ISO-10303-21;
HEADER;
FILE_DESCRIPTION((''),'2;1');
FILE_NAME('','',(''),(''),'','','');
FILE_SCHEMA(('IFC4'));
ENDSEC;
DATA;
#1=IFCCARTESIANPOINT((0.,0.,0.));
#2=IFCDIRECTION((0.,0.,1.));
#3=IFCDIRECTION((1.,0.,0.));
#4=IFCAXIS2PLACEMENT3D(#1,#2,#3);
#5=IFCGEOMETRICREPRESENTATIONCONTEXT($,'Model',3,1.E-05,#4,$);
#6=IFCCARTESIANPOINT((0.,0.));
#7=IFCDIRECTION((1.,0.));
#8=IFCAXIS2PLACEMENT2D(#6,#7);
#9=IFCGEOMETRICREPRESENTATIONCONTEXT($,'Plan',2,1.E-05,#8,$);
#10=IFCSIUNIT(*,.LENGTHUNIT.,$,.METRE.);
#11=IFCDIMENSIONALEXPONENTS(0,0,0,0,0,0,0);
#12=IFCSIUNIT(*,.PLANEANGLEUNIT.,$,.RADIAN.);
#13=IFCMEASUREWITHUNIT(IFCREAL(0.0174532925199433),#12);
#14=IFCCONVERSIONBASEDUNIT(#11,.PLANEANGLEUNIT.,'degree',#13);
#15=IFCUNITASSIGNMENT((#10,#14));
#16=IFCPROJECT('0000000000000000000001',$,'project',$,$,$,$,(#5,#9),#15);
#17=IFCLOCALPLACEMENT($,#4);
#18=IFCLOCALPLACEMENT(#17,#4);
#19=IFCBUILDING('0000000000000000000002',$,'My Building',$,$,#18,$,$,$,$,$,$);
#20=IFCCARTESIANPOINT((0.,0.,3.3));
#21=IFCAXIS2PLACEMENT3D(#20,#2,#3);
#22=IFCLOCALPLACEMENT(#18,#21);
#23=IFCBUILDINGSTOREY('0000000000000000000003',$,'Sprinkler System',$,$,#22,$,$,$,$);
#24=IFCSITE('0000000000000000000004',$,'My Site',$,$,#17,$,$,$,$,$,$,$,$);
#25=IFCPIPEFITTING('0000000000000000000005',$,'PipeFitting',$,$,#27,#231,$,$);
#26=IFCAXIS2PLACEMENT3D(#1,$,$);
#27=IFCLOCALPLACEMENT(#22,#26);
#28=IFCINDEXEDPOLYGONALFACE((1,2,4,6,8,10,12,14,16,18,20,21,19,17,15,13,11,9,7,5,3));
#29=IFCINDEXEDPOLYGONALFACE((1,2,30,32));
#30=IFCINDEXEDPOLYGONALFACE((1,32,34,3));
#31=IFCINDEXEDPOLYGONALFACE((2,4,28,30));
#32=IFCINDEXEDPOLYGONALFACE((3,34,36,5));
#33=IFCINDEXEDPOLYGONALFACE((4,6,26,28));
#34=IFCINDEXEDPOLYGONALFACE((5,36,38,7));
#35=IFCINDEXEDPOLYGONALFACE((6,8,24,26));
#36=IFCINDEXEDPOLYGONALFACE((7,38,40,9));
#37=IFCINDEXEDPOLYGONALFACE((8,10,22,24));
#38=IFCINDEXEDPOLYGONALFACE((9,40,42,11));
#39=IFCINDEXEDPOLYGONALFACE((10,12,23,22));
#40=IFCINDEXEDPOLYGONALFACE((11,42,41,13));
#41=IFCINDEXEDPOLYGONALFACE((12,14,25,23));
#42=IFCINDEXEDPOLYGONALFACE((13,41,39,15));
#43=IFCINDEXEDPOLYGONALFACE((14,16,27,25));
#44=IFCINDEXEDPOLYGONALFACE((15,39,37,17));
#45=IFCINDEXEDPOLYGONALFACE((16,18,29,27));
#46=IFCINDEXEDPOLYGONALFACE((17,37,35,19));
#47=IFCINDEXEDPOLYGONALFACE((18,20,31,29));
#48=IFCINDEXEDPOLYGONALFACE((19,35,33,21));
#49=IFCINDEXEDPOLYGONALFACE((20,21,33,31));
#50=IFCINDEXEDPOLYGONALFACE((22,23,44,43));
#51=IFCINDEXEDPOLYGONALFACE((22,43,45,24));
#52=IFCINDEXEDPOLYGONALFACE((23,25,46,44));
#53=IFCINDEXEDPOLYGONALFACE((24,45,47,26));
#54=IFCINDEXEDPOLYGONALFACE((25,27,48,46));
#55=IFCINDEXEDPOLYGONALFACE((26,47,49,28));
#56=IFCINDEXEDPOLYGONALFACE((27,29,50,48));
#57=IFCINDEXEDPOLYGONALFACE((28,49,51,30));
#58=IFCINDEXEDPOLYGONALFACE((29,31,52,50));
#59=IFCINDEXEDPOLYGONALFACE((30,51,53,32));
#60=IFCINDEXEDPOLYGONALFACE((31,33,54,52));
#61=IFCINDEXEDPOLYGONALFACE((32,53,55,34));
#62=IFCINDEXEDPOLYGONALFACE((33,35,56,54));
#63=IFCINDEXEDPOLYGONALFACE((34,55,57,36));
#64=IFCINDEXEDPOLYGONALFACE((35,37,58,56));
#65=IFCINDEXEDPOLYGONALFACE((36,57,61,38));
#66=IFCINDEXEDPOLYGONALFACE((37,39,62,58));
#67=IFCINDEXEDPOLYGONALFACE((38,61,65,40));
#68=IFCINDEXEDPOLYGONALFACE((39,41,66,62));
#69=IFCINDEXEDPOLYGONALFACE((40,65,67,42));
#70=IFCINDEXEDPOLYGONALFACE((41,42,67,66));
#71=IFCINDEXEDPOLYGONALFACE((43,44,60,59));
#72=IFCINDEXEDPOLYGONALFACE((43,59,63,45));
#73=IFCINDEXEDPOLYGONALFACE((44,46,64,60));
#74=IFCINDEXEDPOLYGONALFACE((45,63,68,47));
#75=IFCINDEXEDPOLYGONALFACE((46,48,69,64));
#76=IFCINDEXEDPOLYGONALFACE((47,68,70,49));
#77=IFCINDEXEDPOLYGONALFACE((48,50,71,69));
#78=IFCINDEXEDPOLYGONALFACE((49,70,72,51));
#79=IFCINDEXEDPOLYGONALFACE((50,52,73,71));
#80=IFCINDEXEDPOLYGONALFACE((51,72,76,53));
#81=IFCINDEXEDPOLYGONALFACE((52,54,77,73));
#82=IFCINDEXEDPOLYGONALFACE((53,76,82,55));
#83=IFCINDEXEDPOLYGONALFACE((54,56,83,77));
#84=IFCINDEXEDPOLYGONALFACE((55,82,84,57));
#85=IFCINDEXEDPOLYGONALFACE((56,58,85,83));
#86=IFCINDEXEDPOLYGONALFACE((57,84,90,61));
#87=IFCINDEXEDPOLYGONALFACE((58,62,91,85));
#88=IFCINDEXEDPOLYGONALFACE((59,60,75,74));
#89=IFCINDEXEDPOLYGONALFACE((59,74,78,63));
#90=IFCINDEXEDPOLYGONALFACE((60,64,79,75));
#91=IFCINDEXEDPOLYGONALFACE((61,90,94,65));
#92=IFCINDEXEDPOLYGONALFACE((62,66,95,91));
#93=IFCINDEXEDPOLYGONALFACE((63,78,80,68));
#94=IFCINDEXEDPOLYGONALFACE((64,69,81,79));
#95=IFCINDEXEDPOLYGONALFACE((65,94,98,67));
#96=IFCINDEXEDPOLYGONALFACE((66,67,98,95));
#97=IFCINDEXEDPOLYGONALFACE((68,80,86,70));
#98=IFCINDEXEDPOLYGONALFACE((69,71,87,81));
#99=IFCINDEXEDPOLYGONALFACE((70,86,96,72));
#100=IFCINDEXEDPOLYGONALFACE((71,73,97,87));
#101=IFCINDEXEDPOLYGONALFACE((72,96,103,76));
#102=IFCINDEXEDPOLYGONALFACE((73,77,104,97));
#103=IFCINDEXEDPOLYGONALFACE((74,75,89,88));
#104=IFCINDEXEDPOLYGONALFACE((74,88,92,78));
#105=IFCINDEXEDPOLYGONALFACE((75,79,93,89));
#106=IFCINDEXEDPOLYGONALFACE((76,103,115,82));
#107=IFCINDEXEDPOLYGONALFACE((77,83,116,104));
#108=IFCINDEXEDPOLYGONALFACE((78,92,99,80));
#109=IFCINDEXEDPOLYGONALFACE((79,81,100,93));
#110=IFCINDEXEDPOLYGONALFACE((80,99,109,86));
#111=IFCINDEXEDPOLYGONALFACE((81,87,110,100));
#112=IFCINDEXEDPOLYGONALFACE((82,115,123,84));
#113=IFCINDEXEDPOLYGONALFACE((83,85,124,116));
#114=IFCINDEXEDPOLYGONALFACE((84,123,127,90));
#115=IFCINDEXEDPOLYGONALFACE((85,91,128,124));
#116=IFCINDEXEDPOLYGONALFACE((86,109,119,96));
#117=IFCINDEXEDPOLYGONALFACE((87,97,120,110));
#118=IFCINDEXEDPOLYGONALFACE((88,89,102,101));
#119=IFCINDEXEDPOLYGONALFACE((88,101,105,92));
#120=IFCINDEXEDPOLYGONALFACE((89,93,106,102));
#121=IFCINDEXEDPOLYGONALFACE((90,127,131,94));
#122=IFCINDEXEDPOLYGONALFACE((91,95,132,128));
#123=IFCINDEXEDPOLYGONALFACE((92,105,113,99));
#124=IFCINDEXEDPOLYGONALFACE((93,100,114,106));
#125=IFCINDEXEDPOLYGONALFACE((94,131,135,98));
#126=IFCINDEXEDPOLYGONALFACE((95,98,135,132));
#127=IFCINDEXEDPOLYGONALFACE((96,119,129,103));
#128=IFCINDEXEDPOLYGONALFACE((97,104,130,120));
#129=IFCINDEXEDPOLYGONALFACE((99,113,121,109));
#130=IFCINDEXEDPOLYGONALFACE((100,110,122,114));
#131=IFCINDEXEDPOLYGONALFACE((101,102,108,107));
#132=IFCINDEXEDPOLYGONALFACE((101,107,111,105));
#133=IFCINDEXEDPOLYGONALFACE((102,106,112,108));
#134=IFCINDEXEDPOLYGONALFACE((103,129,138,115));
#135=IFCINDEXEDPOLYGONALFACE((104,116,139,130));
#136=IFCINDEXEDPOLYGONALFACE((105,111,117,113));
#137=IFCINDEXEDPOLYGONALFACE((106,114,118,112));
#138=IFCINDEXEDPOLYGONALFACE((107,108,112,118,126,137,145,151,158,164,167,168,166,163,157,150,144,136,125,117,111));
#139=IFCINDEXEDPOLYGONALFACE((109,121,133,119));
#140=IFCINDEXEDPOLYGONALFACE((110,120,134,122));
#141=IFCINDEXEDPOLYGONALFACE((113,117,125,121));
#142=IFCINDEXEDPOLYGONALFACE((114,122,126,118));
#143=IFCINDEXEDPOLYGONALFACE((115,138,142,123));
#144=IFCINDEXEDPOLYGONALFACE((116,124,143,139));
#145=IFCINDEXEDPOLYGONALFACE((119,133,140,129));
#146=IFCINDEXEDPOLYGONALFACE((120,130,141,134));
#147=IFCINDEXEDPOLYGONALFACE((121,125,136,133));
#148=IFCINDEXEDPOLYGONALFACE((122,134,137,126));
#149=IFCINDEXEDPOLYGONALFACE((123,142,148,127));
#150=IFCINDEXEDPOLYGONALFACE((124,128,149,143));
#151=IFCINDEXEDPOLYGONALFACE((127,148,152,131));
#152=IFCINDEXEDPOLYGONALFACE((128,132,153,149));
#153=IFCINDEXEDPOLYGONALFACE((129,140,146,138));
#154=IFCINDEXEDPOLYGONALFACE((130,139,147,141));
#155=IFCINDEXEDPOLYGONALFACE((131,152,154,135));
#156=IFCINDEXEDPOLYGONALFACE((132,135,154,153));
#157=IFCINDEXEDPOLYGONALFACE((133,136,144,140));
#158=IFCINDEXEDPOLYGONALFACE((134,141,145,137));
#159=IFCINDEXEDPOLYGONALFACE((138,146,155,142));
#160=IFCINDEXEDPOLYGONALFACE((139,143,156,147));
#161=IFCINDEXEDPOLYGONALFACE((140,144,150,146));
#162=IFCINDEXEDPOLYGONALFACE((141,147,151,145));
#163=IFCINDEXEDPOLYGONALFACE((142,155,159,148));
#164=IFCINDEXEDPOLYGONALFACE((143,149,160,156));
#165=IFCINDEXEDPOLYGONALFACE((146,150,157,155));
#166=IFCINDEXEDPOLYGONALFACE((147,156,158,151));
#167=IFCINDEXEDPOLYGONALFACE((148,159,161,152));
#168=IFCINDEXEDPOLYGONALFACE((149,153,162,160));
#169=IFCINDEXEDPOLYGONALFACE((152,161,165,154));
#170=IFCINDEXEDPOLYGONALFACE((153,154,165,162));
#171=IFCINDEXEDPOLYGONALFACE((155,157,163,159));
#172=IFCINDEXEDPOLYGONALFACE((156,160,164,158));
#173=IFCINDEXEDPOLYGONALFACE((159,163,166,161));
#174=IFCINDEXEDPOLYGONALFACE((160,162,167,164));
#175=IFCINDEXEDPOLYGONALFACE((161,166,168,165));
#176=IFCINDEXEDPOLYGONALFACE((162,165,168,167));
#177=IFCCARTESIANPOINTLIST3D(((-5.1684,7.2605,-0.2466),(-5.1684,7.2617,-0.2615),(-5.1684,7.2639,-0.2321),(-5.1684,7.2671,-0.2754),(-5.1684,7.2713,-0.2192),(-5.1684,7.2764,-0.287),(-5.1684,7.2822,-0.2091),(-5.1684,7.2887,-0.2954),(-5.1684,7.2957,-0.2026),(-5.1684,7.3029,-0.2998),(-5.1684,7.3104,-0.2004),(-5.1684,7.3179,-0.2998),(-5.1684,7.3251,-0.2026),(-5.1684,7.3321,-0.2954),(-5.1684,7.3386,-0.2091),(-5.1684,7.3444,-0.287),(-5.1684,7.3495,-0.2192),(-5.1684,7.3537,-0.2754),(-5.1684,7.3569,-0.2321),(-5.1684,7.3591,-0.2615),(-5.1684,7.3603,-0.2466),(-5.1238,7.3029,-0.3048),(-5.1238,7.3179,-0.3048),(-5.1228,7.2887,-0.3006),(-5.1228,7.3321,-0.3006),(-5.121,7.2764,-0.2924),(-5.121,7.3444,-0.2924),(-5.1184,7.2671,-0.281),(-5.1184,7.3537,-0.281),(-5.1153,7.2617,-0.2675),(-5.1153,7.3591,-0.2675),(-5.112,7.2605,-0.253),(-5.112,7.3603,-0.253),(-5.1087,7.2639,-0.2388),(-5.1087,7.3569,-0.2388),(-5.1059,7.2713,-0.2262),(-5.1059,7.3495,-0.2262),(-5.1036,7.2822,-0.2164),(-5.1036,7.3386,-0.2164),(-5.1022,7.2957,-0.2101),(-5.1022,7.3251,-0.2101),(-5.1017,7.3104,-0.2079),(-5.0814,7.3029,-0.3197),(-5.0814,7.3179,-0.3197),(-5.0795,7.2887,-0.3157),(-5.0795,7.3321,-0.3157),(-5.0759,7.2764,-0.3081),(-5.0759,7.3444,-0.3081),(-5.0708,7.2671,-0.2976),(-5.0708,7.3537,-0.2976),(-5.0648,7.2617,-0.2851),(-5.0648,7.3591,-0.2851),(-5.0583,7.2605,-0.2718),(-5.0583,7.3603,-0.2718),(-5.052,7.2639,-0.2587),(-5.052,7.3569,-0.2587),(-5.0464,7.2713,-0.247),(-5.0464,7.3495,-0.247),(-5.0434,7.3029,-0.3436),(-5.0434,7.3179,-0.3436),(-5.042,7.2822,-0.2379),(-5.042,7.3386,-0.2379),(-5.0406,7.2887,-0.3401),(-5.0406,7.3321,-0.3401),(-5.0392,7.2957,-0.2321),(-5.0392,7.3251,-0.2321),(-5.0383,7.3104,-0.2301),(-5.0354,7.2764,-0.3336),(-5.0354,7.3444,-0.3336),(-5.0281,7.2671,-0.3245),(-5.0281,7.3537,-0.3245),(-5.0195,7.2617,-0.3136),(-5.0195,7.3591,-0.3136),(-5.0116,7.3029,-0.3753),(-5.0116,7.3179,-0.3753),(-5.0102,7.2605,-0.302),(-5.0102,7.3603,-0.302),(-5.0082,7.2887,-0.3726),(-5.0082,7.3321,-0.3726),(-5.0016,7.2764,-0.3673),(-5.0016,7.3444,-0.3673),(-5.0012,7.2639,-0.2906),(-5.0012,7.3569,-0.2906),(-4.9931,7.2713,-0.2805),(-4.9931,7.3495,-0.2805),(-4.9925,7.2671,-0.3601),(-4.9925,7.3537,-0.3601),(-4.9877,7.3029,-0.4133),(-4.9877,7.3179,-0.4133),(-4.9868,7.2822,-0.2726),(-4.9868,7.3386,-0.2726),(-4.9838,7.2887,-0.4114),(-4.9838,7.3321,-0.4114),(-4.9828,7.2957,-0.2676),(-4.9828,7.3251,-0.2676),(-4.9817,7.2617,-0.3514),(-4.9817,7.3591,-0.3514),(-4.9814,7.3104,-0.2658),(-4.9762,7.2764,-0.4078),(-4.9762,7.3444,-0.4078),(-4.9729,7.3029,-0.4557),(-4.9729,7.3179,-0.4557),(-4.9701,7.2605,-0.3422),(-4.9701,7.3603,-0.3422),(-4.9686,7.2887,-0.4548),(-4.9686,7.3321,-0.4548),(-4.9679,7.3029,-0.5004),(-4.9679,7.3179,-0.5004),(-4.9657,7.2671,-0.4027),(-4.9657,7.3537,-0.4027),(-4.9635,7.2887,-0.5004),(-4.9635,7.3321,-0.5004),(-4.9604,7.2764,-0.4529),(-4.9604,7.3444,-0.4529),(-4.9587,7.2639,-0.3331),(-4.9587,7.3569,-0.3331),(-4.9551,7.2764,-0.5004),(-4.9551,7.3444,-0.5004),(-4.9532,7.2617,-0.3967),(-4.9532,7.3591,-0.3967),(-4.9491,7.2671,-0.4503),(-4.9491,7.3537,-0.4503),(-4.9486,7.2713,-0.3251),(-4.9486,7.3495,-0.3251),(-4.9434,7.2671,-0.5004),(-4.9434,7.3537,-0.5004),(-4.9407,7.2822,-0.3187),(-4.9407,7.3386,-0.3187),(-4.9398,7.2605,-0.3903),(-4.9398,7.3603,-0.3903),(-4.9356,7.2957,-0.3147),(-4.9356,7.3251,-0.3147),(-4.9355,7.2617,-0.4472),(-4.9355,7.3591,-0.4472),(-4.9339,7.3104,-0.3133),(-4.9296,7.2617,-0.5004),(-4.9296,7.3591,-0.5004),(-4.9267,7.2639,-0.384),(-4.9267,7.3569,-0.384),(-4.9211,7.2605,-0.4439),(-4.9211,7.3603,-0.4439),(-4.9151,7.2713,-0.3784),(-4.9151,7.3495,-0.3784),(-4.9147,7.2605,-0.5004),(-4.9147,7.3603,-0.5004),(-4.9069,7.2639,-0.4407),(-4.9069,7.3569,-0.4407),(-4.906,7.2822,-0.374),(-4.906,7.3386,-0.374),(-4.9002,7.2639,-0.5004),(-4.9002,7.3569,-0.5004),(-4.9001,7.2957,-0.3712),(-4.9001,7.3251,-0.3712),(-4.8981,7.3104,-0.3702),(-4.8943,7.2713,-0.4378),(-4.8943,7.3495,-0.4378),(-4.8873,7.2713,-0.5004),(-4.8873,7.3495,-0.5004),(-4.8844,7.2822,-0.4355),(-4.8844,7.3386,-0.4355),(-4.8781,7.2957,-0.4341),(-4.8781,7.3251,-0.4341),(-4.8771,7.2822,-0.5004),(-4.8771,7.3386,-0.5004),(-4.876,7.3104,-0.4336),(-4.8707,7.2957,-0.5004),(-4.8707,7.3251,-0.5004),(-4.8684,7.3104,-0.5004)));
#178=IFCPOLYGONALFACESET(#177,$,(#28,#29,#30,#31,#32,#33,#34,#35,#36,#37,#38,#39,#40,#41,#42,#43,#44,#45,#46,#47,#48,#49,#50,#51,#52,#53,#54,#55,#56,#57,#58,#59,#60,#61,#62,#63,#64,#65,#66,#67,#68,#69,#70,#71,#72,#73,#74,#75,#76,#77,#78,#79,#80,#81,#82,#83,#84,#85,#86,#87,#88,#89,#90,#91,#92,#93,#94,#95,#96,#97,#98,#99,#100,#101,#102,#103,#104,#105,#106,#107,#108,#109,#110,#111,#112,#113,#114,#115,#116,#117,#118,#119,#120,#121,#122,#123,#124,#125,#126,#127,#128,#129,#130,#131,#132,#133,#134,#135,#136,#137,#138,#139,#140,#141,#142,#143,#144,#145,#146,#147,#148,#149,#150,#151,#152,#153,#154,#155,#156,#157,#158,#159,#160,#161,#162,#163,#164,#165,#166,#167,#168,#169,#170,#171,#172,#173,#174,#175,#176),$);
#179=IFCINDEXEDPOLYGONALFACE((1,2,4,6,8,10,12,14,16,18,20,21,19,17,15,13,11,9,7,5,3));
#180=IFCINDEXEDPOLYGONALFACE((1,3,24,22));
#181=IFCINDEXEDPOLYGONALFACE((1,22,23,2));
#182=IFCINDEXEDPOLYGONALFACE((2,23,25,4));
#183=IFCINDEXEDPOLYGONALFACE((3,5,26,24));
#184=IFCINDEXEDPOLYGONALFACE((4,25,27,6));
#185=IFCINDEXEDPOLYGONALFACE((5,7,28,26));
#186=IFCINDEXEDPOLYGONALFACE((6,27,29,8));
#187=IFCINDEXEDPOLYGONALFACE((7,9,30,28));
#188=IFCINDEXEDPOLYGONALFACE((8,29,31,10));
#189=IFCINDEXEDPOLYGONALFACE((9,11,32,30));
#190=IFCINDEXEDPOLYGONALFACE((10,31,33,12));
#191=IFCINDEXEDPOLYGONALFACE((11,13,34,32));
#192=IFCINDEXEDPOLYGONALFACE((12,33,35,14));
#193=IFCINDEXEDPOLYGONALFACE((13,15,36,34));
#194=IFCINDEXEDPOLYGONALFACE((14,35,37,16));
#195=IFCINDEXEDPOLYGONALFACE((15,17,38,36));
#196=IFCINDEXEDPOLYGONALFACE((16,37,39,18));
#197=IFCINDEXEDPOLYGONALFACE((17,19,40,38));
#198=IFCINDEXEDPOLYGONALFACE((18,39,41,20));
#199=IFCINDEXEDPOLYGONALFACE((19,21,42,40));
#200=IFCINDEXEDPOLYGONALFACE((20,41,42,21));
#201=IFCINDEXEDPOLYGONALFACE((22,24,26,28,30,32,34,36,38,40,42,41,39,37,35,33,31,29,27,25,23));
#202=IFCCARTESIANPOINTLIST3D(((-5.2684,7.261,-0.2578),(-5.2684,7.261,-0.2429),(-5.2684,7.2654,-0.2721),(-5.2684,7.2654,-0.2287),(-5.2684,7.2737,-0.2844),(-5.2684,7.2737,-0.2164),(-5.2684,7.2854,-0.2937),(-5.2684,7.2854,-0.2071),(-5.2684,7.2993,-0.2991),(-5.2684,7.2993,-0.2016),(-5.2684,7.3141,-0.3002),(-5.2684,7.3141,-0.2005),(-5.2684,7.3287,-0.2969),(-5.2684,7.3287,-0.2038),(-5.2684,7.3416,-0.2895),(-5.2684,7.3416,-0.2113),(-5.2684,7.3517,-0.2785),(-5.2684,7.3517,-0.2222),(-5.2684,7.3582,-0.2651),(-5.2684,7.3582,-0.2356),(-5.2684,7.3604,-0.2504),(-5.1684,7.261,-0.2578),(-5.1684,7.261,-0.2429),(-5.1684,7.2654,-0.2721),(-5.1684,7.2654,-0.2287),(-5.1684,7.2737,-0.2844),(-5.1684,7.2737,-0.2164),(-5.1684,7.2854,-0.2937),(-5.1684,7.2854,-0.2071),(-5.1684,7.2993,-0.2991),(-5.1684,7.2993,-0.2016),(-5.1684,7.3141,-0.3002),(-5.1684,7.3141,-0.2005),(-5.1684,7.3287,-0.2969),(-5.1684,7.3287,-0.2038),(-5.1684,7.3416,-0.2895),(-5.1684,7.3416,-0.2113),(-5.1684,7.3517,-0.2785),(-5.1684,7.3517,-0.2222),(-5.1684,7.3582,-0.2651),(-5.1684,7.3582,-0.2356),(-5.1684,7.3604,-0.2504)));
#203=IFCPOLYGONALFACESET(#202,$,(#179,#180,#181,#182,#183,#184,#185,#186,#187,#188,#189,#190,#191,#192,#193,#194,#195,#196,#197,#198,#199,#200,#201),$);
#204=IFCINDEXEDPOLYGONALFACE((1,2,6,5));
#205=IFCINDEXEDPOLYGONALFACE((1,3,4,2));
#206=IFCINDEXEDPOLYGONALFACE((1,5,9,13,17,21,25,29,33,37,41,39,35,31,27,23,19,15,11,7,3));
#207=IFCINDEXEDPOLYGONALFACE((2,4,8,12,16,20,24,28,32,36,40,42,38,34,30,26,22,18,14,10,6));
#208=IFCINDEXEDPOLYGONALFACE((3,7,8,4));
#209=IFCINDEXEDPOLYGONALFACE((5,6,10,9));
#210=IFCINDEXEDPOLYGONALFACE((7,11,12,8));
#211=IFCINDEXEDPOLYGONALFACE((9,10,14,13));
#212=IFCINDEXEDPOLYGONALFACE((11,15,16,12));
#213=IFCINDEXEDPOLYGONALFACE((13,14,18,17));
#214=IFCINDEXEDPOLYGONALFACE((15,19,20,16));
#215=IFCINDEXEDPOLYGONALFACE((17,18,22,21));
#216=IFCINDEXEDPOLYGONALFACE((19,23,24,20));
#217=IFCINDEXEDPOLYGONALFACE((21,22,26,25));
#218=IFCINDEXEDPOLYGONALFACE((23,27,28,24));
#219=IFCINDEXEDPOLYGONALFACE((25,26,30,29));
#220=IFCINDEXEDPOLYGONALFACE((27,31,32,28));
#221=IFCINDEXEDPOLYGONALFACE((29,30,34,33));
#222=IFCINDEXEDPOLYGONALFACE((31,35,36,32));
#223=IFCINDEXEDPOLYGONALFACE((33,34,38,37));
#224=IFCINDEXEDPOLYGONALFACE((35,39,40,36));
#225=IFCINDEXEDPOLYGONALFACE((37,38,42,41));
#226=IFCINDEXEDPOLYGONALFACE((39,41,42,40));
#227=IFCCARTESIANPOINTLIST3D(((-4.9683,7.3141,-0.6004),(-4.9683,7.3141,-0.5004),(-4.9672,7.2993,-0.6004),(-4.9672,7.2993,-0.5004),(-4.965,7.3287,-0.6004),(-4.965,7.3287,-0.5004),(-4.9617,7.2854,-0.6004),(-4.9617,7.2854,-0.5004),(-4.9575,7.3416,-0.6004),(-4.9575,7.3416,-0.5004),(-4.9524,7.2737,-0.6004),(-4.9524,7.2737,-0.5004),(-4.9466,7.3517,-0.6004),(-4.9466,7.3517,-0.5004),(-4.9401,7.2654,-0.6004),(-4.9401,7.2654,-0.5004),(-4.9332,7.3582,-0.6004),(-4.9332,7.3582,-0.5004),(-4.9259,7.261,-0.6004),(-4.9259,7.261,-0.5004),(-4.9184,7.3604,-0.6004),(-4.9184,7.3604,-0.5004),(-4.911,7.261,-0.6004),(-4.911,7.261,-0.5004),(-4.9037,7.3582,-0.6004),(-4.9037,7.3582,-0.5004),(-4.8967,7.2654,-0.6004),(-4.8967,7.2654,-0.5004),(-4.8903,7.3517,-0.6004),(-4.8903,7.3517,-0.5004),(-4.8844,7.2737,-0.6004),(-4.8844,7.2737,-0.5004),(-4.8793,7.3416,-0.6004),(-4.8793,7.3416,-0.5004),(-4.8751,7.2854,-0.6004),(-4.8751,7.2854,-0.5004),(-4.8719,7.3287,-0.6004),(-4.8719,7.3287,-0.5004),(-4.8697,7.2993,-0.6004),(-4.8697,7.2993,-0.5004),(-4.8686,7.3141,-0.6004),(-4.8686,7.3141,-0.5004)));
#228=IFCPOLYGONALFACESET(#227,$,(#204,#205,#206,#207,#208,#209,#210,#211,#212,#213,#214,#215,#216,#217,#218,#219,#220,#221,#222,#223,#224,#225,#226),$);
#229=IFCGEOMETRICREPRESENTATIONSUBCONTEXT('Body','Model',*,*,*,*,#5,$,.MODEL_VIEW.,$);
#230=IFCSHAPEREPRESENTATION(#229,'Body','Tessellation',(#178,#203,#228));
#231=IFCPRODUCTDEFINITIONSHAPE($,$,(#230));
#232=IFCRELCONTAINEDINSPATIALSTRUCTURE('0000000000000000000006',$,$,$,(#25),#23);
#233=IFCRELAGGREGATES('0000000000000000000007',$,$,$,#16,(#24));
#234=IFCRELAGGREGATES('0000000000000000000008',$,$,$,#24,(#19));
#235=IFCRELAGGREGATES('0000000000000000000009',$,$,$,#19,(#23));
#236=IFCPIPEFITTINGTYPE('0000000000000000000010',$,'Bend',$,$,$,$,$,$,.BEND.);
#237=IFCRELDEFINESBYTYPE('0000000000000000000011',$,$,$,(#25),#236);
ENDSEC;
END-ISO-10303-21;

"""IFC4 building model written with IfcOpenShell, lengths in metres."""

from ifc_helpers import new_model, entity, si_unit, converted_unit, frame, origin_with_axes, origin_2d_with_axis, place, context, subcontext, project, spatial, circle, extrude, source, transform, mapped, type_object, type_shapes, element, save


model = new_model("IFC4")

# Units and contexts
model_context = context("Model", 3, precision=1e-05, world=origin_with_axes())
plan_context = context("Plan", 2, precision=1e-05, world=origin_2d_with_axis())
body_context = subcontext(model_context, "Body", "Model", "MODEL_VIEW")
ifc_project = project(units=[si_unit("LENGTHUNIT", "METRE"), converted_unit("PLANEANGLEUNIT", "degree", entity("IfcReal", 0.0174532925199433), si_unit("PLANEANGLEUNIT", "RADIAN"), dimensions=[0, 0, 0, 0, 0, 0, 0])], contexts=[model_context, plan_context])

# Site, building, storey
site_placement = place(None, origin_with_axes())
site = spatial("IfcSite", under=ifc_project, at=site_placement, Name="My Site")
building_placement = place(site_placement, origin_with_axes())
building = spatial("IfcBuilding", under=site, at=building_placement, Name="My Building")
storey_placement = place(building_placement, frame((0.0, 0.0, 3.3), z_axis=(0.0, 0.0, 1.0), x_axis=(1.0, 0.0, 0.0)))
storey = spatial("IfcBuildingStorey", under=building, at=storey_placement, Name="Sprinkler System")

# Pipe fitting
pipe_fitting_type_1 = type_object("IfcPipeFittingType", Name="Bend", PredefinedType="BEND")
shared_shape_1 = source(origin_with_axes(), body_context, "Body", "SolidModel", [
    entity("IfcSweptDiskSolid", entity("IfcIndexedPolyCurve", entity("IfcCartesianPointList3D", [[0.0, 0.0, -0.1], [0.0, 0.0732, -0.2768], [0.0, 0.25, -0.35]]), [entity("IfcArcIndex", [1, 2, 3])]), 0.05),
    extrude(circle(Radius=0.05), origin_with_axes(), (0.0, 0.0, -1.0), 0.1),
    extrude(circle(Radius=0.05), frame((0.0, 0.25, -0.35), z_axis=(0.0, 1.0, 0.0), x_axis=(1.0, 0.0, 0.0)), (0.0, 0.0, 1.0), 0.1),
])
type_shapes(pipe_fitting_type_1, [shared_shape_1])
for number, where, z_axis, x_axis, name in (
    (1, (-5.2684, 7.3104, -0.2504), (-1.0, 0.0, 0.0), (0.0, 1.0, 0.0), "PipeFitting"),
):
    element("IfcPipeFitting", number, at=place(storey_placement, frame(where, z_axis=z_axis, x_axis=x_axis)), inside=storey, type_object=pipe_fitting_type_1, Name=name, context=body_context, shape_type="MappedRepresentation", body=[
        mapped(shared_shape_1, transform((0.0, 0.0, 0.0), x_axis=(1.0, 0.0, 0.0), y_axis=(0.0, 1.0, 0.0), z_axis=(0.0, 0.0, 1.0), scale=1.0)),
    ])

save(model, "model.ifc")
